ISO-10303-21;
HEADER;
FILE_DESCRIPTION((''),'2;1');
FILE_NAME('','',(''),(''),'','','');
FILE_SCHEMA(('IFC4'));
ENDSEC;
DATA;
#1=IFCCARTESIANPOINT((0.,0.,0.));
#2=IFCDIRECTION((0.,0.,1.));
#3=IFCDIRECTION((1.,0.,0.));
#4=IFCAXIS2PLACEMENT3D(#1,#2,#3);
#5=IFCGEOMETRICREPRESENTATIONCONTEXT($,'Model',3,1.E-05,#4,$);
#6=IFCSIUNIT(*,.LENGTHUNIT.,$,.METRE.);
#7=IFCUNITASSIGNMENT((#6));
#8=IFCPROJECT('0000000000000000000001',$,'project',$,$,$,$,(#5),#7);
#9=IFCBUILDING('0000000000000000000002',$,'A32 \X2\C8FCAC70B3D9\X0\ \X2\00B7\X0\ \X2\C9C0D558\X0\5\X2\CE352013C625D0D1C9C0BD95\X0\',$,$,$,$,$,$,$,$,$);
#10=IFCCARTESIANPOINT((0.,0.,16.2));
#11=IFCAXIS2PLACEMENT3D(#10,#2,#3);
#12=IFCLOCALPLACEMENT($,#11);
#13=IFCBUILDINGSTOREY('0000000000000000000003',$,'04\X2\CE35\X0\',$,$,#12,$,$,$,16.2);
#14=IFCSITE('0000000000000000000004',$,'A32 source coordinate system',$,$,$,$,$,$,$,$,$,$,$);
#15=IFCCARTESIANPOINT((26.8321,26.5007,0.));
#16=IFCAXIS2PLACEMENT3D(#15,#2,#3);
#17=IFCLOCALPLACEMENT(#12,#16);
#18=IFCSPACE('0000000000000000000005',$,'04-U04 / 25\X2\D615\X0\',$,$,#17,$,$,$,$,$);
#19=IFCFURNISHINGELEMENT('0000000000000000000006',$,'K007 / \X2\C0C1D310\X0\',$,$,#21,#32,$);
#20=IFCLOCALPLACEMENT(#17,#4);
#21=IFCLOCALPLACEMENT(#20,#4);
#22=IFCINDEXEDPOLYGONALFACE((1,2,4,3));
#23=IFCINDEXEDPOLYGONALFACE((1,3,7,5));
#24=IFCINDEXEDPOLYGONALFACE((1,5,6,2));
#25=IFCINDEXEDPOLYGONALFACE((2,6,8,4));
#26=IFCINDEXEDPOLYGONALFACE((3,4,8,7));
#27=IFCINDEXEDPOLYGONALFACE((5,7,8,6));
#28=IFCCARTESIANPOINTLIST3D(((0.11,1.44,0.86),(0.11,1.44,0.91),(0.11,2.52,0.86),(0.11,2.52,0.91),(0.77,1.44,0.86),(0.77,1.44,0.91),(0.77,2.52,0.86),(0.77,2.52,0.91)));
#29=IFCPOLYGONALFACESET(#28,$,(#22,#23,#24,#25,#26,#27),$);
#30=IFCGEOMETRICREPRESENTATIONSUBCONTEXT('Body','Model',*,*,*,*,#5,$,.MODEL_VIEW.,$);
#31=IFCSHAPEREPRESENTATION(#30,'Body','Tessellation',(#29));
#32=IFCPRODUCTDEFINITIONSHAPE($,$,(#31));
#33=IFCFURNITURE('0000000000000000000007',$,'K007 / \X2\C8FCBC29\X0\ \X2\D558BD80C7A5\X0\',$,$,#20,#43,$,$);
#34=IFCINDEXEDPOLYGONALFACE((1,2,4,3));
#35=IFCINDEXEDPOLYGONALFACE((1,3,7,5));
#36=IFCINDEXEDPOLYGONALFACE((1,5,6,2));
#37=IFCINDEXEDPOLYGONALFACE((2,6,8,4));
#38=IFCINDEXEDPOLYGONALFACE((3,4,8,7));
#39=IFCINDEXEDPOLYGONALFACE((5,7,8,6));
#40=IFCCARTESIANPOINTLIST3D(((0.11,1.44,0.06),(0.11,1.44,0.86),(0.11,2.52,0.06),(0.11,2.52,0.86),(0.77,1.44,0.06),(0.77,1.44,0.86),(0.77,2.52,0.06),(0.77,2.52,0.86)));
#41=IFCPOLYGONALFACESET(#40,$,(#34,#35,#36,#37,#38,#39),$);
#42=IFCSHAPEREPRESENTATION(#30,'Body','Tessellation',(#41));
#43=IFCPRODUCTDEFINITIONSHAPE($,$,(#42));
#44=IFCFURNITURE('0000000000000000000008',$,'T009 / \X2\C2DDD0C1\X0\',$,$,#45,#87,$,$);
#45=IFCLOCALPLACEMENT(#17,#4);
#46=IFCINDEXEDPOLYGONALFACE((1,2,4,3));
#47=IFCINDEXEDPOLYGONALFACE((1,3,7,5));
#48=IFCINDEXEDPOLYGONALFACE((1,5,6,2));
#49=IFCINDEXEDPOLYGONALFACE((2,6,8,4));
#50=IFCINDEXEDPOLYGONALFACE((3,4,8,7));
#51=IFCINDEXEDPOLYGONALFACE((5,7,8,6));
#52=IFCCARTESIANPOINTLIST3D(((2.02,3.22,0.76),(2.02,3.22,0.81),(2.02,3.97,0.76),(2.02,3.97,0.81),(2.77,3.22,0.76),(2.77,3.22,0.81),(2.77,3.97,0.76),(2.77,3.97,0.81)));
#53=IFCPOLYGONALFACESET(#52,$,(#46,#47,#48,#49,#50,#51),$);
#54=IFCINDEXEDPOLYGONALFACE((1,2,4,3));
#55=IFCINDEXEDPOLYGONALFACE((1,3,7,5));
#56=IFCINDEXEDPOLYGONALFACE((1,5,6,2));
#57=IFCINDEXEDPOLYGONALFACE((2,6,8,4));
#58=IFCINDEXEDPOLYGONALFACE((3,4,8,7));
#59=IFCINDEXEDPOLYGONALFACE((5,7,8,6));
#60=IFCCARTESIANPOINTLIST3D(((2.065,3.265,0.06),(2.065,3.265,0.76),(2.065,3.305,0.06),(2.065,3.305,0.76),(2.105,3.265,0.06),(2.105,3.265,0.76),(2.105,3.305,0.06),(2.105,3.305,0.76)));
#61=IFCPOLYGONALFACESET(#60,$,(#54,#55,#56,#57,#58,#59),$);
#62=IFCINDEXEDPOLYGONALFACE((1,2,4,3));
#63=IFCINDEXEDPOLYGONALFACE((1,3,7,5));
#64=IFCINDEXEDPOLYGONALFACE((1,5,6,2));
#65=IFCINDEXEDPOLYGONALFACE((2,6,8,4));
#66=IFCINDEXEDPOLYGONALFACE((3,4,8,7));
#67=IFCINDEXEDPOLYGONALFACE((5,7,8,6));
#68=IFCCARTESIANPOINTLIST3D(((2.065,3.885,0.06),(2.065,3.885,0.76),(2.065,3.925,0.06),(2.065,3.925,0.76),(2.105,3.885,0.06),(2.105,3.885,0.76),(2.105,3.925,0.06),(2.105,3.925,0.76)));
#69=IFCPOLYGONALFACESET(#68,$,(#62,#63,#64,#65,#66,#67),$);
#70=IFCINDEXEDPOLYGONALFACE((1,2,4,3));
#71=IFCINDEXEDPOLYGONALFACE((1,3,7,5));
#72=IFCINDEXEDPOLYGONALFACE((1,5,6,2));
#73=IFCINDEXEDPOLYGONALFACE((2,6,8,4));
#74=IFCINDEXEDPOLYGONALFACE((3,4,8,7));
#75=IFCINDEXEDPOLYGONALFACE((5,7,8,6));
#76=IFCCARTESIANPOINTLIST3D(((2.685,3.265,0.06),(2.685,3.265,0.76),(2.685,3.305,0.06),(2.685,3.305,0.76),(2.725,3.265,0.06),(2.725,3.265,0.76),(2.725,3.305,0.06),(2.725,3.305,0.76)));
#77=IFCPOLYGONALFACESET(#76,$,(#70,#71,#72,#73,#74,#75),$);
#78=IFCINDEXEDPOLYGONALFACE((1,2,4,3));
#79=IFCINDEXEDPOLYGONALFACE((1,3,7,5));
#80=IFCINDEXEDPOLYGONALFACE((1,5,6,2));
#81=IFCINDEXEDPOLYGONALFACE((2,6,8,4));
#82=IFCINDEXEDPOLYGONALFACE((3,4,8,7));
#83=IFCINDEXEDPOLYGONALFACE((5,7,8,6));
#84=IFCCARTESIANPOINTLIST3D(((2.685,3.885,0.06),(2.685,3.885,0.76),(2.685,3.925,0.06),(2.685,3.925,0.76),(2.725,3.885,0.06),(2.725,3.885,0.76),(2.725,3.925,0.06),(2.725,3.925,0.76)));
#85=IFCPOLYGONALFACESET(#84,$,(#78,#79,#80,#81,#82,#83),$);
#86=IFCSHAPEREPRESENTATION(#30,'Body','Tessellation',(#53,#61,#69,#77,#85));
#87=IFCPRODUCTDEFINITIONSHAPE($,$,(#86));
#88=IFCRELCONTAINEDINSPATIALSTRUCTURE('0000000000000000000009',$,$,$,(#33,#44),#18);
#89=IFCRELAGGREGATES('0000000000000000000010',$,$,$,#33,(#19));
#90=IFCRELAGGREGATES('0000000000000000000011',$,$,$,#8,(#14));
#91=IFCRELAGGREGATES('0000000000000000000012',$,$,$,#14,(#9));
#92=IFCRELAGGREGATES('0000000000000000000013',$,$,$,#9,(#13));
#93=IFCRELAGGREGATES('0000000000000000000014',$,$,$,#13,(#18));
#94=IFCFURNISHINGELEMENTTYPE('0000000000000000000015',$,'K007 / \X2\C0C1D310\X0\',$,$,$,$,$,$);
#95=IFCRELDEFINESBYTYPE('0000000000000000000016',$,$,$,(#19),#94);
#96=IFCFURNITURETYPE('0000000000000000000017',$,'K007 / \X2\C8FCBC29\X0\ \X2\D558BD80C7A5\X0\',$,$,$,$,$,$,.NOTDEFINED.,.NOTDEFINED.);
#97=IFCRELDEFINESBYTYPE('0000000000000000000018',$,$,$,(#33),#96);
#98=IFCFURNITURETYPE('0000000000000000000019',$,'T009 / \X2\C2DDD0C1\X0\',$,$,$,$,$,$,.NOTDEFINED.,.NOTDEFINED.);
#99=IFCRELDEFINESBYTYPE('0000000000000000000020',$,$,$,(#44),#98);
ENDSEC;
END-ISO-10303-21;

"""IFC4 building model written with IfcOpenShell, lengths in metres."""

from ifc_helpers import new_model, si_unit, frame, origin, origin_with_axes, place, context, subcontext, project, spatial, polyline, outline, extrude, source, transform, mapped, type_object, type_shapes, element, aggregate, save


model = new_model("IFC4")

# Units and contexts
model_context = context("Model", 3, precision=1e-05, world=origin_with_axes())
body_context = subcontext(model_context, "Body", "Model", "MODEL_VIEW")
ifc_project = project(units=[si_unit("LENGTHUNIT", "METRE")], contexts=[model_context])

# Site, building, storey
site = spatial("IfcSite", under=ifc_project, Name="A32 source coordinate system")
building = spatial("IfcBuilding", under=site, Name="A32 주거동 · 지하5층–옥탑지붕")
storey_placement = place(None, frame((0.0, 0.0, 16.2), z_axis=(0.0, 0.0, 1.0), x_axis=(1.0, 0.0, 0.0)))
storey = spatial("IfcBuildingStorey", under=building, at=storey_placement, Name="04층", Elevation=16.2)

# Shared definitions
space_1_placement = place(storey_placement, frame((26.8321, 26.5007, 0.0), z_axis=(0.0, 0.0, 1.0), x_axis=(1.0, 0.0, 0.0)))
space_1 = spatial("IfcSpace", under=storey, at=space_1_placement, Name="04-U04 / 25형")

# Furnishing element
furnishing_element_type_1 = type_object("IfcFurnishingElementType", Name="K007 / 상판")
shared_shape_1 = source(origin(), body_context, "Body", "SweptSolid", [
    extrude(outline(polyline([(0.77, 2.52), (0.77, 1.44), (0.11, 1.44), (0.11, 2.52), (0.77, 2.52)])), frame((0.0, 0.0, 0.86)), (0.0, 0.0, 1.0), 0.05),
])
type_shapes(furnishing_element_type_1, [shared_shape_1])
furniture_1_placement = place(space_1_placement, origin_with_axes())
furnishing_1_placement = place(furniture_1_placement, origin_with_axes())
furnishing_1 = element("IfcFurnishingElement", 1, at=furnishing_1_placement, type_object=furnishing_element_type_1, Name="K007 / 상판", context=body_context, shape_type="MappedRepresentation", body=[
    mapped(shared_shape_1, transform((0.0, 0.0, 0.0), scale=1.0)),
])

# Furniture
furniture_type_1 = type_object("IfcFurnitureType", Name="K007 / 주방 하부장", AssemblyPlace="NOTDEFINED", PredefinedType="NOTDEFINED")
shared_shape_2 = source(origin(), body_context, "Body", "SweptSolid", [
    extrude(outline(polyline([(0.11, 2.52), (0.77, 2.52), (0.77, 1.44), (0.11, 1.44), (0.11, 2.52)])), frame((0.0, 0.0, 0.06)), (0.0, 0.0, 1.0), 0.8),
])
type_shapes(furniture_type_1, [shared_shape_2])
furniture_1 = element("IfcFurniture", 2, at=furniture_1_placement, inside=space_1, type_object=furniture_type_1, Name="K007 / 주방 하부장", context=body_context, shape_type="MappedRepresentation", body=[
    mapped(shared_shape_2, transform((0.0, 0.0, 0.0), scale=1.0)),
])
aggregate(furniture_1, [furnishing_1])
furniture_type_2 = type_object("IfcFurnitureType", Name="T009 / 식탁", AssemblyPlace="NOTDEFINED", PredefinedType="NOTDEFINED")
shared_shape_3 = source(origin(), body_context, "Body", "SweptSolid", [
    extrude(outline(polyline([(2.77, 3.22), (2.02, 3.22), (2.02, 3.97), (2.77, 3.97), (2.77, 3.22)])), frame((0.0, 0.0, 0.76)), (0.0, 0.0, 1.0), 0.05),
    extrude(outline(polyline([(2.065, 3.265), (2.065, 3.305), (2.105, 3.305), (2.105, 3.265), (2.065, 3.265)])), frame((0.0, 0.0, 0.06)), (0.0, 0.0, 1.0), 0.7),
    extrude(outline(polyline([(2.065, 3.885), (2.065, 3.925), (2.105, 3.925), (2.105, 3.885), (2.065, 3.885)])), frame((0.0, 0.0, 0.06)), (0.0, 0.0, 1.0), 0.7),
    extrude(outline(polyline([(2.685, 3.265), (2.685, 3.305), (2.725, 3.305), (2.725, 3.265), (2.685, 3.265)])), frame((0.0, 0.0, 0.06)), (0.0, 0.0, 1.0), 0.7),
    extrude(outline(polyline([(2.685, 3.885), (2.685, 3.925), (2.725, 3.925), (2.725, 3.885), (2.685, 3.885)])), frame((0.0, 0.0, 0.06)), (0.0, 0.0, 1.0), 0.7),
])
type_shapes(furniture_type_2, [shared_shape_3])
furniture_2_placement = place(space_1_placement, origin_with_axes())
element("IfcFurniture", 3, at=furniture_2_placement, inside=space_1, type_object=furniture_type_2, Name="T009 / 식탁", context=body_context, shape_type="MappedRepresentation", body=[
    mapped(shared_shape_3, transform((0.0, 0.0, 0.0), scale=1.0)),
])

save(model, "model.ifc")
